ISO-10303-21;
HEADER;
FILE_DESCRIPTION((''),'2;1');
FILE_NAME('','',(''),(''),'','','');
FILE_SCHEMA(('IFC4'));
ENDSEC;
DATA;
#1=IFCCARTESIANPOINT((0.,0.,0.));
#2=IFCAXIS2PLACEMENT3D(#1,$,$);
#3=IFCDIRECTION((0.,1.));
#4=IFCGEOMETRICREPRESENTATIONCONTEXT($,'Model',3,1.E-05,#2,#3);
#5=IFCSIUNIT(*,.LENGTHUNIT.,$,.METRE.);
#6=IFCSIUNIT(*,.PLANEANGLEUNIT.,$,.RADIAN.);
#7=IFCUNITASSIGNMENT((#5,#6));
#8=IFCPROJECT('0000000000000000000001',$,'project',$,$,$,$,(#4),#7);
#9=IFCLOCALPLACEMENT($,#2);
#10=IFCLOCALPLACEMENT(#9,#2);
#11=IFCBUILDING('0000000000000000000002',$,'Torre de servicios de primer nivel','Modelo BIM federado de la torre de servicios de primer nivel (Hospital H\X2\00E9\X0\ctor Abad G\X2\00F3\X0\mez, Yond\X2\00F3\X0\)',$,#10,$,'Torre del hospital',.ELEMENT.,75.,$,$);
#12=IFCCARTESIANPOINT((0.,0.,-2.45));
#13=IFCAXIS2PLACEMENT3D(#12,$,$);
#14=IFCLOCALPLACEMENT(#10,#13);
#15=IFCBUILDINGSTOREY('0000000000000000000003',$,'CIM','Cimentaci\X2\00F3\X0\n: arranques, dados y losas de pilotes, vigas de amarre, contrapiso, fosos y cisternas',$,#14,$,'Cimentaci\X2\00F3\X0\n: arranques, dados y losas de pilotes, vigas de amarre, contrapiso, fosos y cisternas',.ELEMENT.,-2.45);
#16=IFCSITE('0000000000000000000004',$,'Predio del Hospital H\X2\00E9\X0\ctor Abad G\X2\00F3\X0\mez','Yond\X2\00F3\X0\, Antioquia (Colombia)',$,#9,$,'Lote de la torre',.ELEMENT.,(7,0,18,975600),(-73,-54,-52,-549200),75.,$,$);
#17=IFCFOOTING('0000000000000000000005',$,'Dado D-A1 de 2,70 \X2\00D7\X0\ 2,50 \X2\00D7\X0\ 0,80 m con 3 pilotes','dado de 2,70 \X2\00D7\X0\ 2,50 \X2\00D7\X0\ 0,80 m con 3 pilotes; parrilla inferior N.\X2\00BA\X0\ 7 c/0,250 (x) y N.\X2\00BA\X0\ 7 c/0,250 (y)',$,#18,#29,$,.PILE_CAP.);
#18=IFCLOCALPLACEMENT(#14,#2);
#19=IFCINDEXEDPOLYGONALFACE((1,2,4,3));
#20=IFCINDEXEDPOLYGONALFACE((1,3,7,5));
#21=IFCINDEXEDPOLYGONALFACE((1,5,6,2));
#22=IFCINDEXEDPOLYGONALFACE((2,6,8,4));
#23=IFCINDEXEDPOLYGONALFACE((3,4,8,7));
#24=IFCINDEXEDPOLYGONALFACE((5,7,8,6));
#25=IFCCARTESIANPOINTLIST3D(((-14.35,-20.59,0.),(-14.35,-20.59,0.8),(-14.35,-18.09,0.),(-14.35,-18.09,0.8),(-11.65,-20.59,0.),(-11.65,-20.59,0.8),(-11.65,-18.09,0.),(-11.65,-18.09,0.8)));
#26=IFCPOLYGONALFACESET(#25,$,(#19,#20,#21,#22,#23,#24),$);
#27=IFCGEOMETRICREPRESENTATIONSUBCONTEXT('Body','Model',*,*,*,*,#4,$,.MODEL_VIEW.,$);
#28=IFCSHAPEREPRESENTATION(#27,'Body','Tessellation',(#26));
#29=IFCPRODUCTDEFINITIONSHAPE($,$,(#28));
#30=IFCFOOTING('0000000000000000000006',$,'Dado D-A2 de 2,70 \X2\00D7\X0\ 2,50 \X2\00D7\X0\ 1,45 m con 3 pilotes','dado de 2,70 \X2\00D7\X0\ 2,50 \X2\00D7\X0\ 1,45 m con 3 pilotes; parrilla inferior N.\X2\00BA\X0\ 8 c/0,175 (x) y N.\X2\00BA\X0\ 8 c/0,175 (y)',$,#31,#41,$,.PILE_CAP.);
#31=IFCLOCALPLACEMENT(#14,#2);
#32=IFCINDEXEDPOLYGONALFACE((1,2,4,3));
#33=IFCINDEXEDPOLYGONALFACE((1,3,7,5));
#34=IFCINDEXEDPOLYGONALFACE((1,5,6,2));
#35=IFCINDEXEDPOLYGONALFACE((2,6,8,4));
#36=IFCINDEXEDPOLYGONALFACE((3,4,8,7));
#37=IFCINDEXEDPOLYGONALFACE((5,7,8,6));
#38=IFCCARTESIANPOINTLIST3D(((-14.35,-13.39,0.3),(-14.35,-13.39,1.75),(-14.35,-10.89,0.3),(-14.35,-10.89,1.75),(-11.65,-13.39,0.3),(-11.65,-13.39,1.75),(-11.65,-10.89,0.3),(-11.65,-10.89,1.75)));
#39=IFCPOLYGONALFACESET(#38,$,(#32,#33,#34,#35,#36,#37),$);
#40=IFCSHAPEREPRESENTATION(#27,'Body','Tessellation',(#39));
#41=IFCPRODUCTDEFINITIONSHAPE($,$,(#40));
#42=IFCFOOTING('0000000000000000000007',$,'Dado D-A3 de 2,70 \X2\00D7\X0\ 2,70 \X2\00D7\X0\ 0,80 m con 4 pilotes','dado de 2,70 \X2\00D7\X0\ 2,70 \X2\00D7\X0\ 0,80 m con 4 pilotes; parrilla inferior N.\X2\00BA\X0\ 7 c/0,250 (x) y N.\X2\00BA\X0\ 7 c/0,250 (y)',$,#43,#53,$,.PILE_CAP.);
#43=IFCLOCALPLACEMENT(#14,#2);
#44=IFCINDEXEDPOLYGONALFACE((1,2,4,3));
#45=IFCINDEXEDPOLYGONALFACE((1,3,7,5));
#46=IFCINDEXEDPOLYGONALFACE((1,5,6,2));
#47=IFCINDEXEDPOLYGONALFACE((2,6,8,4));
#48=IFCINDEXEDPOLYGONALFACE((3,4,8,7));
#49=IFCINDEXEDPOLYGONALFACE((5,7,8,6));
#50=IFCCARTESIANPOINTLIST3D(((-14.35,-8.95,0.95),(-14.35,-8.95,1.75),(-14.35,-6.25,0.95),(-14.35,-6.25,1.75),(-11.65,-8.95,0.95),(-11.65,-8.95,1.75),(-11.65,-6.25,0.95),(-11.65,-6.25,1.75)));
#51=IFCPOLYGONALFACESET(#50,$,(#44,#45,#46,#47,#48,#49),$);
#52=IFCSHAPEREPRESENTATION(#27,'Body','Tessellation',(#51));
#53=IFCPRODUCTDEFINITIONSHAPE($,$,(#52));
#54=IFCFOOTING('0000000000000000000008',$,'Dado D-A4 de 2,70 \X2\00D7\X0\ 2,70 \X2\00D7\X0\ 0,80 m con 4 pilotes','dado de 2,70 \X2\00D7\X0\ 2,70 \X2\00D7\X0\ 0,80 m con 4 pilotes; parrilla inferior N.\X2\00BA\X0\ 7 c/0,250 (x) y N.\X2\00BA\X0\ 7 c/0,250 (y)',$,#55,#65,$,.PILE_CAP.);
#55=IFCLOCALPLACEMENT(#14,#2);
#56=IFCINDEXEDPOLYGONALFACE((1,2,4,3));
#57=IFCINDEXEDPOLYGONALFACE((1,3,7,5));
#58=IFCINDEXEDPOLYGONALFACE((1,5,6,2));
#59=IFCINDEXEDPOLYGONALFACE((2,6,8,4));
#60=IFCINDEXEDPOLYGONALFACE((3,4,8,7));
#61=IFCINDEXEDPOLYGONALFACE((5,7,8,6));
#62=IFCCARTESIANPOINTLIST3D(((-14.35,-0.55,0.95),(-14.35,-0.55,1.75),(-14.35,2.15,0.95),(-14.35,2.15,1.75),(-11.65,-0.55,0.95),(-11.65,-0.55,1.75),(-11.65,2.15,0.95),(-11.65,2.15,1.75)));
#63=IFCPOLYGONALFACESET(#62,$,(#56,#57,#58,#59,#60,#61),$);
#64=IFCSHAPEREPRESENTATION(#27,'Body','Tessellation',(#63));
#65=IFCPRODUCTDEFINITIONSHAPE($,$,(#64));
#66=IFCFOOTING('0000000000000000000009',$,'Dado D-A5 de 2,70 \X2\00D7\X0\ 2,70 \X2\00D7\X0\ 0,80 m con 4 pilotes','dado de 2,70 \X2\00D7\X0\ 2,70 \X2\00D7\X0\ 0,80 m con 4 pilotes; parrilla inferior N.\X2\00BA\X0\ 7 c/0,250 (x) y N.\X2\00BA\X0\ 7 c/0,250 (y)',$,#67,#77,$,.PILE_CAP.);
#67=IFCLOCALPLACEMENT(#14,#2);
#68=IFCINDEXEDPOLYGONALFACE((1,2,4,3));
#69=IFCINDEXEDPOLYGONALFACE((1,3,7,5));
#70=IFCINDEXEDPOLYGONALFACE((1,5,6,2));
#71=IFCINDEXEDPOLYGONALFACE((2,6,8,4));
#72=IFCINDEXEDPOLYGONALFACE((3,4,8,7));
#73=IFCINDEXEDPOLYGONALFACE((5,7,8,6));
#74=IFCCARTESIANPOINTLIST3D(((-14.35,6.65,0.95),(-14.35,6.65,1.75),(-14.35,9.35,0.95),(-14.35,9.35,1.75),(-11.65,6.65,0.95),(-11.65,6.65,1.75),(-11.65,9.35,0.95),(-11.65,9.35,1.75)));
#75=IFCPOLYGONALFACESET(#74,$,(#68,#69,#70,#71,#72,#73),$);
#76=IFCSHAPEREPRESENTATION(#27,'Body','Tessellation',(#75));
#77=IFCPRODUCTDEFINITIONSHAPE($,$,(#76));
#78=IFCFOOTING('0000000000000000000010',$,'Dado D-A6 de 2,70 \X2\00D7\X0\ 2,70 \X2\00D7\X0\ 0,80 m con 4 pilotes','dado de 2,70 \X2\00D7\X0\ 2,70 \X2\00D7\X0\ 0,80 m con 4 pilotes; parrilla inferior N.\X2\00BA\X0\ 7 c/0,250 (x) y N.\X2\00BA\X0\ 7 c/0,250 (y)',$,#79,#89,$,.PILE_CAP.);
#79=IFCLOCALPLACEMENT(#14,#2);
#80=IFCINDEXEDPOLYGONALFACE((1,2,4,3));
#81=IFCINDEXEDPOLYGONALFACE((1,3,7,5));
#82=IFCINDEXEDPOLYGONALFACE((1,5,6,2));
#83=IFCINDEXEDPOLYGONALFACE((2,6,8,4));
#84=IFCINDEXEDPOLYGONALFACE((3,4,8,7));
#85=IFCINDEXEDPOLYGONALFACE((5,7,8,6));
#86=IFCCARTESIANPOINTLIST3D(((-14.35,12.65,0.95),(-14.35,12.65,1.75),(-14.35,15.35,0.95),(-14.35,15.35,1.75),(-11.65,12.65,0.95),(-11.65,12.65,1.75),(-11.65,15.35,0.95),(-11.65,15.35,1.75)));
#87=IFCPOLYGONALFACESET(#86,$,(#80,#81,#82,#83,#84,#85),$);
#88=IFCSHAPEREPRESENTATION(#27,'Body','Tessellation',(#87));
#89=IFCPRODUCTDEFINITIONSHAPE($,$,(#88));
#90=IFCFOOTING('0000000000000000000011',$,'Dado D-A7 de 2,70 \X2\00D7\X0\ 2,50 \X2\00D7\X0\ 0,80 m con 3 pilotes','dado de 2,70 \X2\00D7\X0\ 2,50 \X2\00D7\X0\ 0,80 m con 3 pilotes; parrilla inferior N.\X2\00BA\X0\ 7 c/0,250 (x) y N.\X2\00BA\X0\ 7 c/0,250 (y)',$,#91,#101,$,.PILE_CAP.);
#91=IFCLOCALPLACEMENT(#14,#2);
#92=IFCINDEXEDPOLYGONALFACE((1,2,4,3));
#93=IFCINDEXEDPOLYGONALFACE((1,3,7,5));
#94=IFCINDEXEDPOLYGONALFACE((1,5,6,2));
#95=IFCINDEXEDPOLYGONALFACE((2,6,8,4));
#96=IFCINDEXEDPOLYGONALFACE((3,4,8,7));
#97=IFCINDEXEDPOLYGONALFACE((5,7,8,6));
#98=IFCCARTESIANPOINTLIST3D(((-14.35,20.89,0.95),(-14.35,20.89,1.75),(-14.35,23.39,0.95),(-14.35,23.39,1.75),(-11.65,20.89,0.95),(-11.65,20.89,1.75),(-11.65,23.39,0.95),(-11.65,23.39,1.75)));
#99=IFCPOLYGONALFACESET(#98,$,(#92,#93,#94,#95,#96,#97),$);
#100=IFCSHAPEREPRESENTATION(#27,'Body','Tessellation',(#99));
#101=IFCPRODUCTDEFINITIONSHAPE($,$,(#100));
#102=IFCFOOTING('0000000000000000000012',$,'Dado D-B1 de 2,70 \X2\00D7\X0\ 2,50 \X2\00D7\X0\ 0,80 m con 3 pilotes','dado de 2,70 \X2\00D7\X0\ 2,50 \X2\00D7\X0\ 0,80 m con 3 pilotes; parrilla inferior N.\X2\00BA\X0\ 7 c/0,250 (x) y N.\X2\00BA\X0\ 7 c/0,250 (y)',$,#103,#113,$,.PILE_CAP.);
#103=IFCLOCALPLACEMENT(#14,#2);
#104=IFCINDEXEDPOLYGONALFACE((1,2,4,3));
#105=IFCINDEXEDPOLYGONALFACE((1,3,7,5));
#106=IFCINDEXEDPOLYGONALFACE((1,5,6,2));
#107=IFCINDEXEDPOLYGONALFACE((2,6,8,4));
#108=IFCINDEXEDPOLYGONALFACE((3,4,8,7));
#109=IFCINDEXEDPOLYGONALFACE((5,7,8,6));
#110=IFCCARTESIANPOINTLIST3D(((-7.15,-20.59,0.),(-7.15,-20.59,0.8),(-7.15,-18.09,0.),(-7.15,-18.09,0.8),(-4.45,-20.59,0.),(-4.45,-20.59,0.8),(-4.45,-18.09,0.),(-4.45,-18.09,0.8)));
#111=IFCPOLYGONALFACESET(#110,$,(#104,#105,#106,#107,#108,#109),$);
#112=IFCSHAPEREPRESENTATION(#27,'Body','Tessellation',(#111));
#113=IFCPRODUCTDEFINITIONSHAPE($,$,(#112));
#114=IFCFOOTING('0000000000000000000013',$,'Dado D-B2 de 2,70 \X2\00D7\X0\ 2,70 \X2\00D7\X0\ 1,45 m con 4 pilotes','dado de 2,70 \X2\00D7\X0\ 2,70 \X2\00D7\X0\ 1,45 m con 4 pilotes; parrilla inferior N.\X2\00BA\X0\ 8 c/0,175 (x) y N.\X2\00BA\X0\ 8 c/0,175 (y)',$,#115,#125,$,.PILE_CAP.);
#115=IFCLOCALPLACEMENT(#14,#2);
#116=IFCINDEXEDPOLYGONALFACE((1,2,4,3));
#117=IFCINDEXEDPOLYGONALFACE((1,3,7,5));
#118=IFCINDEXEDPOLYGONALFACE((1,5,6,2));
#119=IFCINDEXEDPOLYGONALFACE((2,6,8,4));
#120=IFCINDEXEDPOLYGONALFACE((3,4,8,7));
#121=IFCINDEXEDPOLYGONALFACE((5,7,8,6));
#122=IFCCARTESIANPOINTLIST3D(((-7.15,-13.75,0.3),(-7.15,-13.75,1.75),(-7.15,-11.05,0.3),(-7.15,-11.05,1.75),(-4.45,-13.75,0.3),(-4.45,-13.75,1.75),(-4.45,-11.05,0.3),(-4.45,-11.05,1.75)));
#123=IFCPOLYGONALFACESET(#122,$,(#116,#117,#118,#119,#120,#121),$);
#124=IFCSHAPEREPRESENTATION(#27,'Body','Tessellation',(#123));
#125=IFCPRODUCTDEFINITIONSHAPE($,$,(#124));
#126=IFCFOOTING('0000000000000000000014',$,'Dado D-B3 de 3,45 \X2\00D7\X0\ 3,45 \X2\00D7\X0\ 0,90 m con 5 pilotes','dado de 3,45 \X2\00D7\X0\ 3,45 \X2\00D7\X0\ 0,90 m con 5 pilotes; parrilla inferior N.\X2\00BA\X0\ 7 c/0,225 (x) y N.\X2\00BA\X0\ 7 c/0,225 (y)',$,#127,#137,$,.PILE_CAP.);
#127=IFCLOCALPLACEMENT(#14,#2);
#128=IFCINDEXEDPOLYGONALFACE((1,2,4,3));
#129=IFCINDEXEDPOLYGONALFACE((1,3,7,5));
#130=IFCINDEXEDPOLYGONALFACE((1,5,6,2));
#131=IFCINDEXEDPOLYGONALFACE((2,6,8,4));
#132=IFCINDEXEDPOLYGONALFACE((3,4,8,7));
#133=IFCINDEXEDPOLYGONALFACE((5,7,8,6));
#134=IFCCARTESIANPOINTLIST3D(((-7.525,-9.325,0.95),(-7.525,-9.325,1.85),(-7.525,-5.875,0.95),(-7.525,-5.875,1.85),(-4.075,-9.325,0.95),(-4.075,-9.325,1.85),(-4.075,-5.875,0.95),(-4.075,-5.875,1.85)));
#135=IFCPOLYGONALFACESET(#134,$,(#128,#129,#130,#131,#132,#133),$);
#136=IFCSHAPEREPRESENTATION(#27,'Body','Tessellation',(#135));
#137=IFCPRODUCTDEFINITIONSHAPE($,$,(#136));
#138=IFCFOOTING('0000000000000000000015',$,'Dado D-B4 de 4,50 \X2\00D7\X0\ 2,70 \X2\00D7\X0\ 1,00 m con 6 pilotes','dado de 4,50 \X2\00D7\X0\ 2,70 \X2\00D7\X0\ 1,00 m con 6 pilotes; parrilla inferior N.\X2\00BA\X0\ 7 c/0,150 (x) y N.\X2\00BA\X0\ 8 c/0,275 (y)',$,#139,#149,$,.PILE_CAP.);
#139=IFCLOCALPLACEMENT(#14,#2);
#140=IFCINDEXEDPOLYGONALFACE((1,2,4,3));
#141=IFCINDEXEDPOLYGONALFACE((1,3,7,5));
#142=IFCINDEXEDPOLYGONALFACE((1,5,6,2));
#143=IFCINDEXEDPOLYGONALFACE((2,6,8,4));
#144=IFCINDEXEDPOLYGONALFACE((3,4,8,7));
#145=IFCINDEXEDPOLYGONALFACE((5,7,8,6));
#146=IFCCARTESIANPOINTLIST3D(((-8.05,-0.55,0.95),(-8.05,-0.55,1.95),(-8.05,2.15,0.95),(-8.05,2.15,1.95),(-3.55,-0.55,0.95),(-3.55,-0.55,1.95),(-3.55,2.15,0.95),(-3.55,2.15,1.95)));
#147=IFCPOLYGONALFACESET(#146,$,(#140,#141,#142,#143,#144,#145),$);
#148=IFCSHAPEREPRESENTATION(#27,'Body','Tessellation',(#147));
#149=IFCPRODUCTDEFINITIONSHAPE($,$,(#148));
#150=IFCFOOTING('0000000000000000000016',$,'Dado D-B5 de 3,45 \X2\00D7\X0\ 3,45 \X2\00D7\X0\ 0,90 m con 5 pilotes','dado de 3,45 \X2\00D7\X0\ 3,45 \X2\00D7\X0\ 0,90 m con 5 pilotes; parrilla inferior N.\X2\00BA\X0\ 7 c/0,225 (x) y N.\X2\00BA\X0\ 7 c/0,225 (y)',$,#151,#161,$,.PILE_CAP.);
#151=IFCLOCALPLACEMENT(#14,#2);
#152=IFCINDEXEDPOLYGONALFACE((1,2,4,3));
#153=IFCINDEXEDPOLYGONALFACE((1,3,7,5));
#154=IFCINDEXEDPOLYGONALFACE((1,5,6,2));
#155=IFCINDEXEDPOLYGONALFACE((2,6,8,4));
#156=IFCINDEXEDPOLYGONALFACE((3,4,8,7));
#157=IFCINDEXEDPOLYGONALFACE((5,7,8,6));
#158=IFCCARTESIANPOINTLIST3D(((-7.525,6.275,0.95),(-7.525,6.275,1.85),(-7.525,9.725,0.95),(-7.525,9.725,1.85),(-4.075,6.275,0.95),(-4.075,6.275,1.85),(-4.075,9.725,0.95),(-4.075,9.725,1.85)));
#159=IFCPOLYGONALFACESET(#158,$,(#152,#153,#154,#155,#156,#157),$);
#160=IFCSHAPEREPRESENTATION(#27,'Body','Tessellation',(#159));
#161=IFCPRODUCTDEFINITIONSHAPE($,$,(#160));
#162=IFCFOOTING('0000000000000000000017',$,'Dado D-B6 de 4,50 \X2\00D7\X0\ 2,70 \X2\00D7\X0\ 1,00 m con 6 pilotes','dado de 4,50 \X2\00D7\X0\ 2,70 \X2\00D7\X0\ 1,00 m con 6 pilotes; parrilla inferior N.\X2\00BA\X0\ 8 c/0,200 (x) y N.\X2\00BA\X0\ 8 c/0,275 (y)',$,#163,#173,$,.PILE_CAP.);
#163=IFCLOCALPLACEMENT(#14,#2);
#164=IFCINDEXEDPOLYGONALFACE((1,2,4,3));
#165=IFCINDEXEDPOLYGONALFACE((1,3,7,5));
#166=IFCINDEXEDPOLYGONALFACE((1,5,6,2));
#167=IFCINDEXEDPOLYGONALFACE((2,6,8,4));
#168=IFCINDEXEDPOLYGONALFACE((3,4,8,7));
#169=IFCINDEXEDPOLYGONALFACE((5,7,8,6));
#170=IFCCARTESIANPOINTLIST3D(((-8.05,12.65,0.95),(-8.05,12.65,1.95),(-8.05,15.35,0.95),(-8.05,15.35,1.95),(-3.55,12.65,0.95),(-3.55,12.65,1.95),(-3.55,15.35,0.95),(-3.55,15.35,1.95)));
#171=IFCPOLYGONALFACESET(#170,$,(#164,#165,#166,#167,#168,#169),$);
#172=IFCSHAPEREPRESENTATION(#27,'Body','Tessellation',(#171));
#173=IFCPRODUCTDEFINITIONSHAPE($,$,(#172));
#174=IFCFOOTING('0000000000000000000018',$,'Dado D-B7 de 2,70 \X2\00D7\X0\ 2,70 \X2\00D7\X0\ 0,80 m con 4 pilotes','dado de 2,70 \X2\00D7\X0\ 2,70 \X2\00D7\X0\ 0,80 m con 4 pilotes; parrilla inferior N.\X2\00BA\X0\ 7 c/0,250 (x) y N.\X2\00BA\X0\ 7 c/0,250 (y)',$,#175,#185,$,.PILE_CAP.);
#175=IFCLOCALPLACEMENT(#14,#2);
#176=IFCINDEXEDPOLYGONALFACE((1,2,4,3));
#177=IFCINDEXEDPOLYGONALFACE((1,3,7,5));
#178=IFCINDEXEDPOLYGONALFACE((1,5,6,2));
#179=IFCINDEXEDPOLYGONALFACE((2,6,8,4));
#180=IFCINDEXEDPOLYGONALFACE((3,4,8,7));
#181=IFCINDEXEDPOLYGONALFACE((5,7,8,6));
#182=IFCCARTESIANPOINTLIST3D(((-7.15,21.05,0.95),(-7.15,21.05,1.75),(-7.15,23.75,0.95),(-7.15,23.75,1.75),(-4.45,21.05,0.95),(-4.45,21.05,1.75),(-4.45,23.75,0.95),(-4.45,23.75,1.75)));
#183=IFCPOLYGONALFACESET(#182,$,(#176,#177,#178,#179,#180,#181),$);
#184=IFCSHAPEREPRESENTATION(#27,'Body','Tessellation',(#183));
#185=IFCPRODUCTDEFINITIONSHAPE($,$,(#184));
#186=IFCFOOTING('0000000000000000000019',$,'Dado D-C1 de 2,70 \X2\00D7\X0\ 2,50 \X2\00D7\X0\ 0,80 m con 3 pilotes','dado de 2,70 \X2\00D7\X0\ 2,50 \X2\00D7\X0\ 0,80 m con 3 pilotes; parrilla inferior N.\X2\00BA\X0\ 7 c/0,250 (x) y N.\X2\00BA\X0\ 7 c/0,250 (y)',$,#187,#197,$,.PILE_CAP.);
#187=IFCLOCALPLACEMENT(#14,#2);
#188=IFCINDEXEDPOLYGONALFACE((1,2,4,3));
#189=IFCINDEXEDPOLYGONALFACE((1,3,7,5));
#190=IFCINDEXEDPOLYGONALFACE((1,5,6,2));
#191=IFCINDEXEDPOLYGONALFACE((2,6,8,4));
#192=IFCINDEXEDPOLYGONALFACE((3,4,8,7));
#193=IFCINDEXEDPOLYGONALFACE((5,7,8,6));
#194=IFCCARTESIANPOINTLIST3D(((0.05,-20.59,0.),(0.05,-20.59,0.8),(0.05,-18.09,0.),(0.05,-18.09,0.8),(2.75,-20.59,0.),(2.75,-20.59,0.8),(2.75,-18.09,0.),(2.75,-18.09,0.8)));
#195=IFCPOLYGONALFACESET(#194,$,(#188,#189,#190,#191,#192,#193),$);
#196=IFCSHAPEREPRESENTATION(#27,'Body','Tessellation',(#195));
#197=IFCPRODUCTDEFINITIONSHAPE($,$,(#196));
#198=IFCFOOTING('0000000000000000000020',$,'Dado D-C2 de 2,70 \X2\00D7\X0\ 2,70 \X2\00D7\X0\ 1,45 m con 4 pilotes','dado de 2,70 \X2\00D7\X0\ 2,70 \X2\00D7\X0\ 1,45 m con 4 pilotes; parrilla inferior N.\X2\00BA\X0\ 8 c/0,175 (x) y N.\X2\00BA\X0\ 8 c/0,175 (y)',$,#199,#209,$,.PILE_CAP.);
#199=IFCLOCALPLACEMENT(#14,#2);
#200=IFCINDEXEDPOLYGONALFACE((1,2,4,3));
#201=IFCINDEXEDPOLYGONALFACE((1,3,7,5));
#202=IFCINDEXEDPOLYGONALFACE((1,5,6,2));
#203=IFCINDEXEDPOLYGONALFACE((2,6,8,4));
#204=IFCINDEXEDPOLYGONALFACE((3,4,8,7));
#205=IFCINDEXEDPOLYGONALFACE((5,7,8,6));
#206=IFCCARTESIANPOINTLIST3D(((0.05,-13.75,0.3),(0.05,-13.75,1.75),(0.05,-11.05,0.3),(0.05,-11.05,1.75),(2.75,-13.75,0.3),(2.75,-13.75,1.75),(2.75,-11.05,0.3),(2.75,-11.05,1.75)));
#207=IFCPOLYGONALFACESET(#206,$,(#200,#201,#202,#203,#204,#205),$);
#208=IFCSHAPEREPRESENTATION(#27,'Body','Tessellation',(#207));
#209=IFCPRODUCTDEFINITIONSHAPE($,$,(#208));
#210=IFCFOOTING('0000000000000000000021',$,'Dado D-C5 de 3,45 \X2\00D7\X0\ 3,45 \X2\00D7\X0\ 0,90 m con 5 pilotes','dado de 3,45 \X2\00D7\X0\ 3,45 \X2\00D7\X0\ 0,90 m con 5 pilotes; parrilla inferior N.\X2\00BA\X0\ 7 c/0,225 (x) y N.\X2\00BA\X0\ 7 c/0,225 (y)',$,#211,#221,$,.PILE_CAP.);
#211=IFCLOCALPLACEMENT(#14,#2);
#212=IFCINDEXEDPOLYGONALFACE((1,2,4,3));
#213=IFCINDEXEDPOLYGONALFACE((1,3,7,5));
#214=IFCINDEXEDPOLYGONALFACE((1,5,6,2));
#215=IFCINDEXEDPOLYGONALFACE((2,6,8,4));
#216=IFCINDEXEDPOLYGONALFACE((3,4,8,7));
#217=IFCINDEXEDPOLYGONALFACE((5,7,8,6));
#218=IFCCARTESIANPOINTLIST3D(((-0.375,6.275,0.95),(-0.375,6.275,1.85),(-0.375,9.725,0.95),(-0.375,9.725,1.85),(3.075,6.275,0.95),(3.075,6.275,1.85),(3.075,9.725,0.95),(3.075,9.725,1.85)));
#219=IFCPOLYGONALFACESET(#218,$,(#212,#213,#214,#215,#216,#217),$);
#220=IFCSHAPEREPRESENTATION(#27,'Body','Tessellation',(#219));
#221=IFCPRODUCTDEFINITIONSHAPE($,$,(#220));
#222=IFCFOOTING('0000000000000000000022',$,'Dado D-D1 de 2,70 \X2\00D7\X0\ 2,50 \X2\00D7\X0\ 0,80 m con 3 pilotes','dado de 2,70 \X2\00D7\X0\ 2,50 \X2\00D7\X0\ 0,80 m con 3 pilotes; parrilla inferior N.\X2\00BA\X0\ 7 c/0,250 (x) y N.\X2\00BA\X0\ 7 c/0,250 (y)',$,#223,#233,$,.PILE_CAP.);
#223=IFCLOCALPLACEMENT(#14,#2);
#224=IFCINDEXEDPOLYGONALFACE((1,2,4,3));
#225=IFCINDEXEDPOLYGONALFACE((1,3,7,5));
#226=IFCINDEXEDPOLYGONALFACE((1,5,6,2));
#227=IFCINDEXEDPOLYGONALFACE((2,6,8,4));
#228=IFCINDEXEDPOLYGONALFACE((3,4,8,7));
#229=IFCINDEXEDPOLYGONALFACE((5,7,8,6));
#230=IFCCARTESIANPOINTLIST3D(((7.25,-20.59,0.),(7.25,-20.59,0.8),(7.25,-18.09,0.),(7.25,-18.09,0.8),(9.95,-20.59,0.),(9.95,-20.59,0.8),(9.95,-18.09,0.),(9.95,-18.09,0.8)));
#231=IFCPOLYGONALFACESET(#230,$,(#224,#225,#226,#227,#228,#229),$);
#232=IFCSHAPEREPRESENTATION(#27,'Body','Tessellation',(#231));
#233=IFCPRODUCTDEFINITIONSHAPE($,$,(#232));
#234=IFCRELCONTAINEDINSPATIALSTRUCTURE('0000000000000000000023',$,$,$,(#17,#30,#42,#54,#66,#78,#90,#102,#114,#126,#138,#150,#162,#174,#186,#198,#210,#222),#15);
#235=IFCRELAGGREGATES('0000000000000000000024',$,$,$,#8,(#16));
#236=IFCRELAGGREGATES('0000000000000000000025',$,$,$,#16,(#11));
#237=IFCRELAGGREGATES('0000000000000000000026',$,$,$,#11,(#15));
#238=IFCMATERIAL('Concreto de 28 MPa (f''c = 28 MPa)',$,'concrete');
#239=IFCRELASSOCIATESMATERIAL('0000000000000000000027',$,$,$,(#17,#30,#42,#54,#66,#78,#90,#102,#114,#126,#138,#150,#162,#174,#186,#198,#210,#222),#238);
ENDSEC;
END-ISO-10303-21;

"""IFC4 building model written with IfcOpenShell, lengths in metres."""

from ifc_helpers import new_model, si_unit, direction, frame, origin, place, context, subcontext, project, spatial, rectangle, extrude, material, element, save


model = new_model("IFC4")

# Units and contexts
model_context = context("Model", 3, precision=1e-05, world=origin(), true_north=direction((0.0, 1.0)))
body_context = subcontext(model_context, "Body", "Model", "MODEL_VIEW")
ifc_project = project(units=[si_unit("LENGTHUNIT", "METRE"), si_unit("PLANEANGLEUNIT", "RADIAN")], contexts=[model_context])

# Site, building, storey
site_placement = place(None, origin())
site = spatial("IfcSite", under=ifc_project, at=site_placement, Name="Predio del Hospital Héctor Abad Gómez", Description="Yondó, Antioquia (Colombia)", LongName="Lote de la torre", CompositionType="ELEMENT", RefLatitude=(7, 0, 18, 975600), RefLongitude=(-73, -54, -52, -549200), RefElevation=75.0)
building_placement = place(site_placement, origin())
building = spatial("IfcBuilding", under=site, at=building_placement, Name="Torre de servicios de primer nivel", Description="Modelo BIM federado de la torre de servicios de primer nivel (Hospital Héctor Abad Gómez, Yondó)", LongName="Torre del hospital", CompositionType="ELEMENT", ElevationOfRefHeight=75.0)
placement = place(building_placement, frame((0.0, 0.0, -2.45)))
storey = spatial("IfcBuildingStorey", under=building, at=placement, Name="CIM", Description="Cimentación: arranques, dados y losas de pilotes, vigas de amarre, contrapiso, fosos y cisternas", LongName="Cimentación: arranques, dados y losas de pilotes, vigas de amarre, contrapiso, fosos y cisternas", CompositionType="ELEMENT", Elevation=-2.45)

# Footings
ifc_material = material(Name="Concreto de 28 MPa (f'c = 28 MPa)", Category="concrete")
element("IfcFooting", 1, at=placement, inside=storey, material=ifc_material, Name="Dado D-A1 de 2,70 × 2,50 × 0,80 m con 3 pilotes", Description="dado de 2,70 × 2,50 × 0,80 m con 3 pilotes; parrilla inferior N.º 7 c/0,250 (x) y N.º 7 c/0,250 (y)", PredefinedType="PILE_CAP", context=body_context, shape_type="SweptSolid", body=[
    extrude(rectangle(XDim=2.7, YDim=2.5), frame((-13.0, -19.34, 0.0)), (0.0, 0.0, 1.0), 0.8),
])
element("IfcFooting", 2, at=placement, inside=storey, material=ifc_material, Name="Dado D-A2 de 2,70 × 2,50 × 1,45 m con 3 pilotes", Description="dado de 2,70 × 2,50 × 1,45 m con 3 pilotes; parrilla inferior N.º 8 c/0,175 (x) y N.º 8 c/0,175 (y)", PredefinedType="PILE_CAP", context=body_context, shape_type="SweptSolid", body=[
    extrude(rectangle(XDim=2.7, YDim=2.5), frame((-13.0, -12.14, 0.3)), (0.0, 0.0, 1.0), 1.45),
])
element("IfcFooting", 3, at=placement, inside=storey, material=ifc_material, Name="Dado D-A3 de 2,70 × 2,70 × 0,80 m con 4 pilotes", Description="dado de 2,70 × 2,70 × 0,80 m con 4 pilotes; parrilla inferior N.º 7 c/0,250 (x) y N.º 7 c/0,250 (y)", PredefinedType="PILE_CAP", context=body_context, shape_type="SweptSolid", body=[
    extrude(rectangle(XDim=2.7, YDim=2.7), frame((-13.0, -7.6, 0.95)), (0.0, 0.0, 1.0), 0.8),
])
element("IfcFooting", 4, at=placement, inside=storey, material=ifc_material, Name="Dado D-A4 de 2,70 × 2,70 × 0,80 m con 4 pilotes", Description="dado de 2,70 × 2,70 × 0,80 m con 4 pilotes; parrilla inferior N.º 7 c/0,250 (x) y N.º 7 c/0,250 (y)", PredefinedType="PILE_CAP", context=body_context, shape_type="SweptSolid", body=[
    extrude(rectangle(XDim=2.7, YDim=2.7), frame((-13.0, 0.8, 0.95)), (0.0, 0.0, 1.0), 0.8),
])
element("IfcFooting", 5, at=placement, inside=storey, material=ifc_material, Name="Dado D-A5 de 2,70 × 2,70 × 0,80 m con 4 pilotes", Description="dado de 2,70 × 2,70 × 0,80 m con 4 pilotes; parrilla inferior N.º 7 c/0,250 (x) y N.º 7 c/0,250 (y)", PredefinedType="PILE_CAP", context=body_context, shape_type="SweptSolid", body=[
    extrude(rectangle(XDim=2.7, YDim=2.7), frame((-13.0, 8.0, 0.95)), (0.0, 0.0, 1.0), 0.8),
])
element("IfcFooting", 6, at=placement, inside=storey, material=ifc_material, Name="Dado D-A6 de 2,70 × 2,70 × 0,80 m con 4 pilotes", Description="dado de 2,70 × 2,70 × 0,80 m con 4 pilotes; parrilla inferior N.º 7 c/0,250 (x) y N.º 7 c/0,250 (y)", PredefinedType="PILE_CAP", context=body_context, shape_type="SweptSolid", body=[
    extrude(rectangle(XDim=2.7, YDim=2.7), frame((-13.0, 14.0, 0.95)), (0.0, 0.0, 1.0), 0.8),
])
element("IfcFooting", 7, at=placement, inside=storey, material=ifc_material, Name="Dado D-A7 de 2,70 × 2,50 × 0,80 m con 3 pilotes", Description="dado de 2,70 × 2,50 × 0,80 m con 3 pilotes; parrilla inferior N.º 7 c/0,250 (x) y N.º 7 c/0,250 (y)", PredefinedType="PILE_CAP", context=body_context, shape_type="SweptSolid", body=[
    extrude(rectangle(XDim=2.7, YDim=2.5), frame((-13.0, 22.14, 0.95)), (0.0, 0.0, 1.0), 0.8),
])
element("IfcFooting", 8, at=placement, inside=storey, material=ifc_material, Name="Dado D-B1 de 2,70 × 2,50 × 0,80 m con 3 pilotes", Description="dado de 2,70 × 2,50 × 0,80 m con 3 pilotes; parrilla inferior N.º 7 c/0,250 (x) y N.º 7 c/0,250 (y)", PredefinedType="PILE_CAP", context=body_context, shape_type="SweptSolid", body=[
    extrude(rectangle(XDim=2.7, YDim=2.5), frame((-5.8, -19.34, 0.0)), (0.0, 0.0, 1.0), 0.8),
])
element("IfcFooting", 9, at=placement, inside=storey, material=ifc_material, Name="Dado D-B2 de 2,70 × 2,70 × 1,45 m con 4 pilotes", Description="dado de 2,70 × 2,70 × 1,45 m con 4 pilotes; parrilla inferior N.º 8 c/0,175 (x) y N.º 8 c/0,175 (y)", PredefinedType="PILE_CAP", context=body_context, shape_type="SweptSolid", body=[
    extrude(rectangle(XDim=2.7, YDim=2.7), frame((-5.8, -12.4, 0.3)), (0.0, 0.0, 1.0), 1.45),
])
element("IfcFooting", 10, at=placement, inside=storey, material=ifc_material, Name="Dado D-B3 de 3,45 × 3,45 × 0,90 m con 5 pilotes", Description="dado de 3,45 × 3,45 × 0,90 m con 5 pilotes; parrilla inferior N.º 7 c/0,225 (x) y N.º 7 c/0,225 (y)", PredefinedType="PILE_CAP", context=body_context, shape_type="SweptSolid", body=[
    extrude(rectangle(XDim=3.45, YDim=3.45), frame((-5.8, -7.6, 0.95)), (0.0, 0.0, 1.0), 0.9),
])
element("IfcFooting", 11, at=placement, inside=storey, material=ifc_material, Name="Dado D-B4 de 4,50 × 2,70 × 1,00 m con 6 pilotes", Description="dado de 4,50 × 2,70 × 1,00 m con 6 pilotes; parrilla inferior N.º 7 c/0,150 (x) y N.º 8 c/0,275 (y)", PredefinedType="PILE_CAP", context=body_context, shape_type="SweptSolid", body=[
    extrude(rectangle(XDim=4.5, YDim=2.7), frame((-5.8, 0.8, 0.95)), (0.0, 0.0, 1.0), 1.0),
])
element("IfcFooting", 12, at=placement, inside=storey, material=ifc_material, Name="Dado D-B5 de 3,45 × 3,45 × 0,90 m con 5 pilotes", Description="dado de 3,45 × 3,45 × 0,90 m con 5 pilotes; parrilla inferior N.º 7 c/0,225 (x) y N.º 7 c/0,225 (y)", PredefinedType="PILE_CAP", context=body_context, shape_type="SweptSolid", body=[
    extrude(rectangle(XDim=3.45, YDim=3.45), frame((-5.8, 8.0, 0.95)), (0.0, 0.0, 1.0), 0.9),
])
element("IfcFooting", 13, at=placement, inside=storey, material=ifc_material, Name="Dado D-B6 de 4,50 × 2,70 × 1,00 m con 6 pilotes", Description="dado de 4,50 × 2,70 × 1,00 m con 6 pilotes; parrilla inferior N.º 8 c/0,200 (x) y N.º 8 c/0,275 (y)", PredefinedType="PILE_CAP", context=body_context, shape_type="SweptSolid", body=[
    extrude(rectangle(XDim=4.5, YDim=2.7), frame((-5.8, 14.0, 0.95)), (0.0, 0.0, 1.0), 1.0),
])
element("IfcFooting", 14, at=placement, inside=storey, material=ifc_material, Name="Dado D-B7 de 2,70 × 2,70 × 0,80 m con 4 pilotes", Description="dado de 2,70 × 2,70 × 0,80 m con 4 pilotes; parrilla inferior N.º 7 c/0,250 (x) y N.º 7 c/0,250 (y)", PredefinedType="PILE_CAP", context=body_context, shape_type="SweptSolid", body=[
    extrude(rectangle(XDim=2.7, YDim=2.7), frame((-5.8, 22.4, 0.95)), (0.0, 0.0, 1.0), 0.8),
])
element("IfcFooting", 15, at=placement, inside=storey, material=ifc_material, Name="Dado D-C1 de 2,70 × 2,50 × 0,80 m con 3 pilotes", Description="dado de 2,70 × 2,50 × 0,80 m con 3 pilotes; parrilla inferior N.º 7 c/0,250 (x) y N.º 7 c/0,250 (y)", PredefinedType="PILE_CAP", context=body_context, shape_type="SweptSolid", body=[
    extrude(rectangle(XDim=2.7, YDim=2.5), frame((1.4, -19.34, 0.0)), (0.0, 0.0, 1.0), 0.8),
])
element("IfcFooting", 16, at=placement, inside=storey, material=ifc_material, Name="Dado D-C2 de 2,70 × 2,70 × 1,45 m con 4 pilotes", Description="dado de 2,70 × 2,70 × 1,45 m con 4 pilotes; parrilla inferior N.º 8 c/0,175 (x) y N.º 8 c/0,175 (y)", PredefinedType="PILE_CAP", context=body_context, shape_type="SweptSolid", body=[
    extrude(rectangle(XDim=2.7, YDim=2.7), frame((1.4, -12.4, 0.3)), (0.0, 0.0, 1.0), 1.45),
])
element("IfcFooting", 17, at=placement, inside=storey, material=ifc_material, Name="Dado D-C5 de 3,45 × 3,45 × 0,90 m con 5 pilotes", Description="dado de 3,45 × 3,45 × 0,90 m con 5 pilotes; parrilla inferior N.º 7 c/0,225 (x) y N.º 7 c/0,225 (y)", PredefinedType="PILE_CAP", context=body_context, shape_type="SweptSolid", body=[
    extrude(rectangle(XDim=3.45, YDim=3.45), frame((1.35, 8.0, 0.95)), (0.0, 0.0, 1.0), 0.9),
])
element("IfcFooting", 18, at=placement, inside=storey, material=ifc_material, Name="Dado D-D1 de 2,70 × 2,50 × 0,80 m con 3 pilotes", Description="dado de 2,70 × 2,50 × 0,80 m con 3 pilotes; parrilla inferior N.º 7 c/0,250 (x) y N.º 7 c/0,250 (y)", PredefinedType="PILE_CAP", context=body_context, shape_type="SweptSolid", body=[
    extrude(rectangle(XDim=2.7, YDim=2.5), frame((8.6, -19.34, 0.0)), (0.0, 0.0, 1.0), 0.8),
])

save(model, "model.ifc")
